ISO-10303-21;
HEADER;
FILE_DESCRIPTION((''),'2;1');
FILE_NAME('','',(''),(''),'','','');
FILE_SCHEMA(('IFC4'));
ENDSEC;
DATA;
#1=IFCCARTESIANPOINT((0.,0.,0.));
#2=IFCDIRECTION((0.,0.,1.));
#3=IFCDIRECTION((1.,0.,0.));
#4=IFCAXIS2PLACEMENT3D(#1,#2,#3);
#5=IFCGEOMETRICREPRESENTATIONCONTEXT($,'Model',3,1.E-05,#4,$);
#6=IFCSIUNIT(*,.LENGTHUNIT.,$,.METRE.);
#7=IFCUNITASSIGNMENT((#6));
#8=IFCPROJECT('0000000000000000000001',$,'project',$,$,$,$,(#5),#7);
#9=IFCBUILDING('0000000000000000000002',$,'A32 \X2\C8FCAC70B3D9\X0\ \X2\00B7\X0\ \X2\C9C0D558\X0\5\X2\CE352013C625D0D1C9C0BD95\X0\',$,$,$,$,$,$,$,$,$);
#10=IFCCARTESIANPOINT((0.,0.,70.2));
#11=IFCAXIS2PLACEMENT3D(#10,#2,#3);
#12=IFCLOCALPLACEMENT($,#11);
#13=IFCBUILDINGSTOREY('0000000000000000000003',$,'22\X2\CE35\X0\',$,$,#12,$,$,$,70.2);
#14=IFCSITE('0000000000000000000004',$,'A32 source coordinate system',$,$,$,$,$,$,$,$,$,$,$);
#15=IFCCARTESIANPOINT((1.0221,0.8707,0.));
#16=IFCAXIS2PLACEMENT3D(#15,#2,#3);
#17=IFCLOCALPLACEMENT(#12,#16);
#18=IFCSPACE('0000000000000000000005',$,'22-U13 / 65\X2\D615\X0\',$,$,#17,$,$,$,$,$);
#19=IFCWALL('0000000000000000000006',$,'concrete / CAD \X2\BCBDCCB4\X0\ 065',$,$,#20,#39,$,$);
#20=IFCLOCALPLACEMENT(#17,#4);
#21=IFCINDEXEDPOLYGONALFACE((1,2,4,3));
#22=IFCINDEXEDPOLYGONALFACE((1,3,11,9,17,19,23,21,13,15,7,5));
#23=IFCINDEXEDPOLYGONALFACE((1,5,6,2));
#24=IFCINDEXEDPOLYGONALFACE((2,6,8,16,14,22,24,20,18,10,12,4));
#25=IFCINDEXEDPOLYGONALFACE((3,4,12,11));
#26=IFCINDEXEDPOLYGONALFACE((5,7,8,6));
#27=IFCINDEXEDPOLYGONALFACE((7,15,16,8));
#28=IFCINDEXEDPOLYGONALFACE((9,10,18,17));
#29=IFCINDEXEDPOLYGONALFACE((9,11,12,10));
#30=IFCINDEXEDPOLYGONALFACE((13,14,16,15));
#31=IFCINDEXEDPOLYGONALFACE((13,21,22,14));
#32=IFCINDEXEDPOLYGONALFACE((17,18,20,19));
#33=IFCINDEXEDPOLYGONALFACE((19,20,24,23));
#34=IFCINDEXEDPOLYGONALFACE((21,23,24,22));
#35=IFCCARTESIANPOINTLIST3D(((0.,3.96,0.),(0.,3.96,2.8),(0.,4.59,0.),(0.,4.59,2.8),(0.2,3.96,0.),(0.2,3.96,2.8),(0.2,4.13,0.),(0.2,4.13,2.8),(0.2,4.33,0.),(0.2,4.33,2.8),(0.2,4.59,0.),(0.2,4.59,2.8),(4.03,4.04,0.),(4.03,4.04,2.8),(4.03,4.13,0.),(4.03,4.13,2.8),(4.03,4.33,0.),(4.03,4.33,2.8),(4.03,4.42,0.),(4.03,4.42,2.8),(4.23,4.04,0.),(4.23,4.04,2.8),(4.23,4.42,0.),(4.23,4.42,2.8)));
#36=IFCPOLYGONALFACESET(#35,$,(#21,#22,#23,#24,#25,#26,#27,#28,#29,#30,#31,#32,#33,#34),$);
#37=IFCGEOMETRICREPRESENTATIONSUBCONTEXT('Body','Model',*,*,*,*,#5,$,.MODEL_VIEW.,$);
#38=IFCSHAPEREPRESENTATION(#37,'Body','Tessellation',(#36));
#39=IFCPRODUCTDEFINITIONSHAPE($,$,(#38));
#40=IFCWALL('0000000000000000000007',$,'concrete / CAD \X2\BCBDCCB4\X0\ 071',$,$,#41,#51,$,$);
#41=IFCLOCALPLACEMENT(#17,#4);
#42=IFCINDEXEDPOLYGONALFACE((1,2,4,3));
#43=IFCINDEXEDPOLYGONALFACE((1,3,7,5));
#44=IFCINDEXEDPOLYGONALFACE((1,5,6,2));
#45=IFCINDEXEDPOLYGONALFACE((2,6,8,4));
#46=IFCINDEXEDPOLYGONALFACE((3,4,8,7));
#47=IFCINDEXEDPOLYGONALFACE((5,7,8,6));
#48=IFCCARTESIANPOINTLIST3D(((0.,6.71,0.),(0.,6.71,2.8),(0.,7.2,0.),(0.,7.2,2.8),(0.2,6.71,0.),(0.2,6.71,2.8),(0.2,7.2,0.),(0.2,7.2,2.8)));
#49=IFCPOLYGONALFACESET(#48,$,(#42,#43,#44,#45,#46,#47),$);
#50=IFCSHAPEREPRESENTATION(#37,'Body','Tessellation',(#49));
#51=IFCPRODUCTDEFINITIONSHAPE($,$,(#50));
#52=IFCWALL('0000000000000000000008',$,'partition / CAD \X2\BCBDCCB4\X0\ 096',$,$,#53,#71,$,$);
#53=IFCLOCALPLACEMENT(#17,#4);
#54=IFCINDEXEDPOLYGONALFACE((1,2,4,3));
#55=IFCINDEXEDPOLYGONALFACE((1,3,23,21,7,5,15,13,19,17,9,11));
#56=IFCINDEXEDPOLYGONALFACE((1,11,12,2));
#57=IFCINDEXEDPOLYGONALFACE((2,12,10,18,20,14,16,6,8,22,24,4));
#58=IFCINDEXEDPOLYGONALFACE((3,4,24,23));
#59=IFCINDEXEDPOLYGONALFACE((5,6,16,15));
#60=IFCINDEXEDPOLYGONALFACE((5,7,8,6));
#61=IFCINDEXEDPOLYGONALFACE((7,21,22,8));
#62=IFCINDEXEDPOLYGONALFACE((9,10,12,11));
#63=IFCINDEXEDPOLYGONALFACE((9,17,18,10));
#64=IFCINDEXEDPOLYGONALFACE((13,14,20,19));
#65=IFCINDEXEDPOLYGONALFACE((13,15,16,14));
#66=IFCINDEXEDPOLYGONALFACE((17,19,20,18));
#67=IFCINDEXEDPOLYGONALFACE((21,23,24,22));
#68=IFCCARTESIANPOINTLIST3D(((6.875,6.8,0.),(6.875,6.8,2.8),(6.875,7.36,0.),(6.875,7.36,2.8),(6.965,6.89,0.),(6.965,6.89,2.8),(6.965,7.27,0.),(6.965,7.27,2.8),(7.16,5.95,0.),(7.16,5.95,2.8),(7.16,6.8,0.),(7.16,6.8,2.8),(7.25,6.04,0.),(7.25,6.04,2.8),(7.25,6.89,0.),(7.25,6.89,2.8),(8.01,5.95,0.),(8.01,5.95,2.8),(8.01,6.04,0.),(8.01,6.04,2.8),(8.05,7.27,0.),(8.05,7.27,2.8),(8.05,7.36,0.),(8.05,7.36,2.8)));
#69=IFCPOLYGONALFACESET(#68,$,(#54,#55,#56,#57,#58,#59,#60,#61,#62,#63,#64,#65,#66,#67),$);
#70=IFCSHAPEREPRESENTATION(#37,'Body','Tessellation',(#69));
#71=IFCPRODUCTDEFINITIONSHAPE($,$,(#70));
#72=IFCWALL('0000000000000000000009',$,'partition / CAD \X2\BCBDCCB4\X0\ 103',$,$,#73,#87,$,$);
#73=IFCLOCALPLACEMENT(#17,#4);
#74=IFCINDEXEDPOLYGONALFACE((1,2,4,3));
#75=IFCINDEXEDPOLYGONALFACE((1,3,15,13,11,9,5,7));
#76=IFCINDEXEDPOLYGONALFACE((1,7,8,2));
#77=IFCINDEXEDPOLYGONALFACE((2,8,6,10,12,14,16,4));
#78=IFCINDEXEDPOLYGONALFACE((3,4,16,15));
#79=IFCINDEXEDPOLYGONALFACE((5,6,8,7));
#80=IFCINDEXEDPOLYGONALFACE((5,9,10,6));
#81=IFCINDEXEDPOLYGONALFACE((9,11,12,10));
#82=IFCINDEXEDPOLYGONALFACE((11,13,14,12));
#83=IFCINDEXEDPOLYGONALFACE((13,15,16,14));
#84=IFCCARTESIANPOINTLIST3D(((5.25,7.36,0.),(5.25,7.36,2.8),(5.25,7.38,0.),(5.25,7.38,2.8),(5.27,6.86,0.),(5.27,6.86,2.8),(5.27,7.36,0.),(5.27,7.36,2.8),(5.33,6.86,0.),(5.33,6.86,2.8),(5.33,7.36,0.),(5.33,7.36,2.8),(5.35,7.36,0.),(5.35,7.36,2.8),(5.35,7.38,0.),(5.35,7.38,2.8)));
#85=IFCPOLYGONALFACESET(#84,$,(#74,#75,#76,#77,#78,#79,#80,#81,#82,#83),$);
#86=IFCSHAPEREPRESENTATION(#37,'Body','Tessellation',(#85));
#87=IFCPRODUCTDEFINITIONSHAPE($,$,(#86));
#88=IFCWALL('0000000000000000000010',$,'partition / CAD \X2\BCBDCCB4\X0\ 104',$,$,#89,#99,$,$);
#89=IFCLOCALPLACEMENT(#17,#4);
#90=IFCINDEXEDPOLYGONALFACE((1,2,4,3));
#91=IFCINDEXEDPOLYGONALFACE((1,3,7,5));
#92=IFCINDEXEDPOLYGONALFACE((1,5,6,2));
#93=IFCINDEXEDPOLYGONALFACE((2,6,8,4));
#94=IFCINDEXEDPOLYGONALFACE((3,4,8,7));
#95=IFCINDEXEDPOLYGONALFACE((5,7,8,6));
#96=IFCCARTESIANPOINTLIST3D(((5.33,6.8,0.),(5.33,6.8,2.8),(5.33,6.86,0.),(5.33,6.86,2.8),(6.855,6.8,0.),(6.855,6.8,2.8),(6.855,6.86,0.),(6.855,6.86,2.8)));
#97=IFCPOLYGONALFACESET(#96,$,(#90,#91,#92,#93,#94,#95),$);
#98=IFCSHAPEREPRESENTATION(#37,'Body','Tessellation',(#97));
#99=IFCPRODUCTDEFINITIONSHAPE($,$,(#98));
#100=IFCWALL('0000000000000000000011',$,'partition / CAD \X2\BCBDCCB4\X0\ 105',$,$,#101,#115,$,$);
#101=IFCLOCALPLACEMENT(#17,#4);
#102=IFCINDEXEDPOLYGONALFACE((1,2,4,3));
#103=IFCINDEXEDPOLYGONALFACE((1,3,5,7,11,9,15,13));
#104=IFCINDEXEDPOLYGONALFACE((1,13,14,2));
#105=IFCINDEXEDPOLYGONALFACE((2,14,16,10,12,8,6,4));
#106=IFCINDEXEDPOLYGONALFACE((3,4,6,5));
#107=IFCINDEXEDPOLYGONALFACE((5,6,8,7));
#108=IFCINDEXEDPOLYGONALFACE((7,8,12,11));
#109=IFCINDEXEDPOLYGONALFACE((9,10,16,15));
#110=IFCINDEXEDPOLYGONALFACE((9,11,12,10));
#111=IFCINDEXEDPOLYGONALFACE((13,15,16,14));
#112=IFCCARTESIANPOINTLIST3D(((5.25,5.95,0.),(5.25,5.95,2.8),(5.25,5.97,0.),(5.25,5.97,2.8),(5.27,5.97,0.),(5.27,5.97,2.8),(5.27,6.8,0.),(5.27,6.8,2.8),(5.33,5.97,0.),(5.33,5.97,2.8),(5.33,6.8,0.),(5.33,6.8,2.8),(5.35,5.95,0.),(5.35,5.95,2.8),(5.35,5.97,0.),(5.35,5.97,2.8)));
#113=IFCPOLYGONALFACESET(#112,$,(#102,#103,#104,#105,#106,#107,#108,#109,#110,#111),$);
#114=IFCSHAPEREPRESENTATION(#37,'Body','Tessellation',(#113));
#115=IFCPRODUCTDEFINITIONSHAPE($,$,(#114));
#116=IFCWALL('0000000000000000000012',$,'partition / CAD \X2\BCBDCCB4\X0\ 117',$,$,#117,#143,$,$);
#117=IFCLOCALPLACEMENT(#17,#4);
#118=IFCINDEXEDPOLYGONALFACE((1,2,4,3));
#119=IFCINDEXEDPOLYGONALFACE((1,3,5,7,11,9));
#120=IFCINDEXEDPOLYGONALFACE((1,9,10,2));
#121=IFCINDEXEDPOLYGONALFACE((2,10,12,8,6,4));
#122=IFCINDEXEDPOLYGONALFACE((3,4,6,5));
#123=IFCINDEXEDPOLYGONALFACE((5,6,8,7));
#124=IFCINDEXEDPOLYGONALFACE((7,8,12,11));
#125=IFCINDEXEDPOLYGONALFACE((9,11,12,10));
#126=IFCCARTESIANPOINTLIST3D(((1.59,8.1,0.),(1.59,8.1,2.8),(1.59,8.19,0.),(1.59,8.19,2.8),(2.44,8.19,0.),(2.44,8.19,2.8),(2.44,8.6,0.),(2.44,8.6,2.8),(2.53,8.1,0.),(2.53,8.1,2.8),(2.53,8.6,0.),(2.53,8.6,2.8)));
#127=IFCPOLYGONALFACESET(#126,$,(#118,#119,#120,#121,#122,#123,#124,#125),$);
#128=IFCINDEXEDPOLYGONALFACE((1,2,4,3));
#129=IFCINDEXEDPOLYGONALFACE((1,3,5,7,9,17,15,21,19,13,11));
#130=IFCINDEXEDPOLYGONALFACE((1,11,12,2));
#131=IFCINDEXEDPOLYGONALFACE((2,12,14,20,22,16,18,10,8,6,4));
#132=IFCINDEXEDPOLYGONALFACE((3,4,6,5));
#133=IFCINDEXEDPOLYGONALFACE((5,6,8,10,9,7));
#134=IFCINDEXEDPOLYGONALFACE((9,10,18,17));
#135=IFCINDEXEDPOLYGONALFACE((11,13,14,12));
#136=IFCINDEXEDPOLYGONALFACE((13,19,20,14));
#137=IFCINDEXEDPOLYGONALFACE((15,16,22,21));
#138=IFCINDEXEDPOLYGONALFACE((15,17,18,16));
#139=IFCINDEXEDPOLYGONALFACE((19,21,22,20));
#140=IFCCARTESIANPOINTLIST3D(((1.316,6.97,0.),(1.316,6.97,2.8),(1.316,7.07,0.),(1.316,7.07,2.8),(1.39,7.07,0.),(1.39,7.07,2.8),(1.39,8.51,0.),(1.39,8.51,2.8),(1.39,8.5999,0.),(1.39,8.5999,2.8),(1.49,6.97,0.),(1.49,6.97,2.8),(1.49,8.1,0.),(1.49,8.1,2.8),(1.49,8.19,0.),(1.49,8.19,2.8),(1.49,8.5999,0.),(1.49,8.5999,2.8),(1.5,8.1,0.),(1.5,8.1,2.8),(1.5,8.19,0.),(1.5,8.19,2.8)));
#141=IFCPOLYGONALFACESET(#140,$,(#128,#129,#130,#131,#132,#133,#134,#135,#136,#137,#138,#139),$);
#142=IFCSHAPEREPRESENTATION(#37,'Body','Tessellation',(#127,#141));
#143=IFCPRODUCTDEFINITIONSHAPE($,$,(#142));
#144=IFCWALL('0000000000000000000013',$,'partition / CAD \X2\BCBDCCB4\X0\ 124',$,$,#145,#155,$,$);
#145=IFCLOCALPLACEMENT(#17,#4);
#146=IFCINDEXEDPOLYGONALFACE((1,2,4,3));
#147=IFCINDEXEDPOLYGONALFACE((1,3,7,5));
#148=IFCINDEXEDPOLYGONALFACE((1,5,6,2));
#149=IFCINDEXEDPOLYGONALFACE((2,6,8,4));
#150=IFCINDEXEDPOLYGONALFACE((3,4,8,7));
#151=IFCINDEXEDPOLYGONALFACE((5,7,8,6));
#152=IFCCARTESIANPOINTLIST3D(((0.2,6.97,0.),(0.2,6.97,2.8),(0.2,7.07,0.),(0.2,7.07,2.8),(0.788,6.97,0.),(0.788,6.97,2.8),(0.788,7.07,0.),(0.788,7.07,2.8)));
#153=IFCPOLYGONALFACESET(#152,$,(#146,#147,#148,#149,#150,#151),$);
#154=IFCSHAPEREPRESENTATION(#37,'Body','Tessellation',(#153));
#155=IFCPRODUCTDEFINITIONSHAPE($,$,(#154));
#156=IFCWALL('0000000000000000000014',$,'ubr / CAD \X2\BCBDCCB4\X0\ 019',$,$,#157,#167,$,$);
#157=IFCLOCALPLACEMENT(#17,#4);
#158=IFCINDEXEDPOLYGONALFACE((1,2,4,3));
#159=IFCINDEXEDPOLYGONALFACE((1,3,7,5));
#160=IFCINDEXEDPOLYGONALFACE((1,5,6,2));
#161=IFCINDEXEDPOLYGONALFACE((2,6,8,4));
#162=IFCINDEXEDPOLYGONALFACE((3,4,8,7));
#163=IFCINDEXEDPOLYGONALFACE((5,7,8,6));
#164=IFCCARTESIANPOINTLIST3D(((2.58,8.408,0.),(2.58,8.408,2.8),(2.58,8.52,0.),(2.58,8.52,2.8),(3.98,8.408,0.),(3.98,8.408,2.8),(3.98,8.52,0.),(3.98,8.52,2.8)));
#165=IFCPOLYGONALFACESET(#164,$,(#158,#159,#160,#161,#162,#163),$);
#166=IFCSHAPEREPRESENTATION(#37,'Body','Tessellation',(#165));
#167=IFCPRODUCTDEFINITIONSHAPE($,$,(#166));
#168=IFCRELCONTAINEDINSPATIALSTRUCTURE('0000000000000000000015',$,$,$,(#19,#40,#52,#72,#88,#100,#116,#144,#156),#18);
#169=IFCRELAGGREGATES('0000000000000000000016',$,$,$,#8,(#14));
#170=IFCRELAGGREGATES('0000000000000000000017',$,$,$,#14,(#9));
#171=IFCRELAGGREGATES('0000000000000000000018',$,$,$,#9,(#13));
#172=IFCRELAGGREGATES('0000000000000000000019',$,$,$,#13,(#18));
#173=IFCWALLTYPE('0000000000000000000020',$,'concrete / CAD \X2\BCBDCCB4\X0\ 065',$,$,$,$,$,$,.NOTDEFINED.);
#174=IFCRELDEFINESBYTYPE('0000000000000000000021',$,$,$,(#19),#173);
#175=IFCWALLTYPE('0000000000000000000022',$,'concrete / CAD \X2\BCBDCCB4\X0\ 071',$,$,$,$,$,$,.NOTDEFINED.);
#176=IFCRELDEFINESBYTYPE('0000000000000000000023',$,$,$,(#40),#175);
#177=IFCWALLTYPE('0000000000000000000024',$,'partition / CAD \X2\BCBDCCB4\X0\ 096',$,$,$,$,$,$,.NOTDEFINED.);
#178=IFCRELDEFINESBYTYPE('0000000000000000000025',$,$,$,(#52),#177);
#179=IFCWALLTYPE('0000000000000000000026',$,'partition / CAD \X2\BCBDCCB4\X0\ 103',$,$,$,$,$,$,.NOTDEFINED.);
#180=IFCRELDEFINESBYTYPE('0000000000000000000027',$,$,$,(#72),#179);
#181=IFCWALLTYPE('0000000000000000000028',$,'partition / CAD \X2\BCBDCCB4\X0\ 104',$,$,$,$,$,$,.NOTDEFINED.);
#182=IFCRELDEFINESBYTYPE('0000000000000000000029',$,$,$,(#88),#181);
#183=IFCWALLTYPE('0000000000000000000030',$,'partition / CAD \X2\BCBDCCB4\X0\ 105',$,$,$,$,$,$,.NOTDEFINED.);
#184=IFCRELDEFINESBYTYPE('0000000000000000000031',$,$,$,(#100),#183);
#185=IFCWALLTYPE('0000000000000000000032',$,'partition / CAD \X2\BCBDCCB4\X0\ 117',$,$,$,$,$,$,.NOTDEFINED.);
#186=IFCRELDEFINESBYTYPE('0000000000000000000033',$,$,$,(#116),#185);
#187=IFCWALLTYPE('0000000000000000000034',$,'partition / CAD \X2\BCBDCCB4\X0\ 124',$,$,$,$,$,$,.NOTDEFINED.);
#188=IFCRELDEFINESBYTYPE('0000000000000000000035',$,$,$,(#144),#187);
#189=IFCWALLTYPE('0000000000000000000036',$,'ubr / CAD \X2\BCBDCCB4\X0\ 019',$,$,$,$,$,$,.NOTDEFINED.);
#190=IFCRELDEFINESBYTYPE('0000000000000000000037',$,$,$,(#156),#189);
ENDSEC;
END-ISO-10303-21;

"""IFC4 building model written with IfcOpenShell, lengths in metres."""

from ifc_helpers import new_model, si_unit, frame, origin, origin_with_axes, place, context, subcontext, project, spatial, polyline, outline, extrude, source, transform, mapped, type_object, type_shapes, element, save


model = new_model("IFC4")

# Units and contexts
model_context = context("Model", 3, precision=1e-05, world=origin_with_axes())
body_context = subcontext(model_context, "Body", "Model", "MODEL_VIEW")
ifc_project = project(units=[si_unit("LENGTHUNIT", "METRE")], contexts=[model_context])

# Site, building, storey, space
storey_placement = place(None, frame((0.0, 0.0, 70.2), z_axis=(0.0, 0.0, 1.0), x_axis=(1.0, 0.0, 0.0)))
space_placement = place(storey_placement, frame((1.0221, 0.8707, 0.0), z_axis=(0.0, 0.0, 1.0), x_axis=(1.0, 0.0, 0.0)))
site = spatial("IfcSite", under=ifc_project, Name="A32 source coordinate system")
building = spatial("IfcBuilding", under=site, Name="A32 주거동 · 지하5층–옥탑지붕")
storey = spatial("IfcBuildingStorey", under=building, at=storey_placement, Name="22층", Elevation=70.2)
space = spatial("IfcSpace", under=storey, at=space_placement, Name="22-U13 / 65형")

# Walls
wall_type_1 = type_object("IfcWallType", Name="concrete / CAD 벽체 065", PredefinedType="NOTDEFINED")
shared_shape_1 = source(origin(), body_context, "Body", "SweptSolid", [
    extrude(outline(polyline([(0.2, 4.59), (0.2, 4.33), (4.03, 4.33), (4.03, 4.42), (4.23, 4.42), (4.23, 4.04), (4.03, 4.04), (4.03, 4.13), (0.2, 4.13), (0.2, 3.96), (0.0, 3.96), (0.0, 4.59), (0.2, 4.59)])), origin(), (0.0, 0.0, 1.0), 2.8),
])
type_shapes(wall_type_1, [shared_shape_1])
wall_1_placement = place(space_placement, origin_with_axes())
element("IfcWall", 1, at=wall_1_placement, inside=space, type_object=wall_type_1, Name="concrete / CAD 벽체 065", context=body_context, shape_type="MappedRepresentation", body=[
    mapped(shared_shape_1, transform((0.0, 0.0, 0.0), scale=1.0)),
])
wall_type_2 = type_object("IfcWallType", Name="concrete / CAD 벽체 071", PredefinedType="NOTDEFINED")
shared_shape_2 = source(origin(), body_context, "Body", "SweptSolid", [
    extrude(outline(polyline([(0.2, 6.71), (0.0, 6.71), (0.0, 7.2), (0.2, 7.2), (0.2, 6.71)])), origin(), (0.0, 0.0, 1.0), 2.8),
])
type_shapes(wall_type_2, [shared_shape_2])
wall_2_placement = place(space_placement, origin_with_axes())
element("IfcWall", 2, at=wall_2_placement, inside=space, type_object=wall_type_2, Name="concrete / CAD 벽체 071", context=body_context, shape_type="MappedRepresentation", body=[
    mapped(shared_shape_2, transform((0.0, 0.0, 0.0), scale=1.0)),
])
wall_type_3 = type_object("IfcWallType", Name="partition / CAD 벽체 096", PredefinedType="NOTDEFINED")
shared_shape_3 = source(origin(), body_context, "Body", "SweptSolid", [
    extrude(outline(polyline([(7.25, 6.04), (8.01, 6.04), (8.01, 5.95), (7.16, 5.95), (7.16, 6.8), (6.875, 6.8), (6.875, 7.36), (8.05, 7.36), (8.05, 7.27), (6.965, 7.27), (6.965, 6.89), (7.25, 6.89), (7.25, 6.04)])), origin(), (0.0, 0.0, 1.0), 2.8),
])
type_shapes(wall_type_3, [shared_shape_3])
wall_3_placement = place(space_placement, origin_with_axes())
element("IfcWall", 3, at=wall_3_placement, inside=space, type_object=wall_type_3, Name="partition / CAD 벽체 096", context=body_context, shape_type="MappedRepresentation", body=[
    mapped(shared_shape_3, transform((0.0, 0.0, 0.0), scale=1.0)),
])
wall_type_4 = type_object("IfcWallType", Name="partition / CAD 벽체 103", PredefinedType="NOTDEFINED")
shared_shape_4 = source(origin(), body_context, "Body", "SweptSolid", [
    extrude(outline(polyline([(5.27, 7.36), (5.25, 7.36), (5.25, 7.38), (5.35, 7.38), (5.35, 7.36), (5.33, 7.36), (5.33, 6.86), (5.27, 6.86), (5.27, 7.36)])), origin(), (0.0, 0.0, 1.0), 2.8),
])
type_shapes(wall_type_4, [shared_shape_4])
wall_4_placement = place(space_placement, origin_with_axes())
element("IfcWall", 4, at=wall_4_placement, inside=space, type_object=wall_type_4, Name="partition / CAD 벽체 103", context=body_context, shape_type="MappedRepresentation", body=[
    mapped(shared_shape_4, transform((0.0, 0.0, 0.0), scale=1.0)),
])
wall_type_5 = type_object("IfcWallType", Name="partition / CAD 벽체 104", PredefinedType="NOTDEFINED")
shared_shape_5 = source(origin(), body_context, "Body", "SweptSolid", [
    extrude(outline(polyline([(6.855, 6.86), (6.855, 6.8), (5.33, 6.8), (5.33, 6.86), (6.855, 6.86)])), origin(), (0.0, 0.0, 1.0), 2.8),
])
type_shapes(wall_type_5, [shared_shape_5])
wall_5_placement = place(space_placement, origin_with_axes())
element("IfcWall", 5, at=wall_5_placement, inside=space, type_object=wall_type_5, Name="partition / CAD 벽체 104", context=body_context, shape_type="MappedRepresentation", body=[
    mapped(shared_shape_5, transform((0.0, 0.0, 0.0), scale=1.0)),
])
wall_type_6 = type_object("IfcWallType", Name="partition / CAD 벽체 105", PredefinedType="NOTDEFINED")
shared_shape_6 = source(origin(), body_context, "Body", "SweptSolid", [
    extrude(outline(polyline([(5.25, 5.97), (5.27, 5.97), (5.27, 6.8), (5.33, 6.8), (5.33, 5.97), (5.35, 5.97), (5.35, 5.95), (5.25, 5.95), (5.25, 5.97)])), origin(), (0.0, 0.0, 1.0), 2.8),
])
type_shapes(wall_type_6, [shared_shape_6])
wall_6_placement = place(space_placement, origin_with_axes())
element("IfcWall", 6, at=wall_6_placement, inside=space, type_object=wall_type_6, Name="partition / CAD 벽체 105", context=body_context, shape_type="MappedRepresentation", body=[
    mapped(shared_shape_6, transform((0.0, 0.0, 0.0), scale=1.0)),
])
wall_type_7 = type_object("IfcWallType", Name="partition / CAD 벽체 117", PredefinedType="NOTDEFINED")
shared_shape_7 = source(origin(), body_context, "Body", "SweptSolid", [
    extrude(outline(polyline([(2.53, 8.1), (1.59, 8.1), (1.59, 8.19), (2.44, 8.19), (2.44, 8.6), (2.53, 8.6), (2.53, 8.1)])), origin(), (0.0, 0.0, 1.0), 2.8),
    extrude(outline(polyline([(1.49, 8.1), (1.49, 6.97), (1.316, 6.97), (1.316, 7.07), (1.39, 7.07), (1.39, 8.51), (1.39, 8.5999), (1.49, 8.5999), (1.49, 8.19), (1.5, 8.19), (1.5, 8.1), (1.49, 8.1)])), origin(), (0.0, 0.0, 1.0), 2.8),
])
type_shapes(wall_type_7, [shared_shape_7])
wall_7_placement = place(space_placement, origin_with_axes())
element("IfcWall", 7, at=wall_7_placement, inside=space, type_object=wall_type_7, Name="partition / CAD 벽체 117", context=body_context, shape_type="MappedRepresentation", body=[
    mapped(shared_shape_7, transform((0.0, 0.0, 0.0), scale=1.0)),
])
wall_type_8 = type_object("IfcWallType", Name="partition / CAD 벽체 124", PredefinedType="NOTDEFINED")
shared_shape_8 = source(origin(), body_context, "Body", "SweptSolid", [
    extrude(outline(polyline([(0.788, 7.07), (0.788, 6.97), (0.2, 6.97), (0.2, 7.07), (0.788, 7.07)])), origin(), (0.0, 0.0, 1.0), 2.8),
])
type_shapes(wall_type_8, [shared_shape_8])
wall_8_placement = place(space_placement, origin_with_axes())
element("IfcWall", 8, at=wall_8_placement, inside=space, type_object=wall_type_8, Name="partition / CAD 벽체 124", context=body_context, shape_type="MappedRepresentation", body=[
    mapped(shared_shape_8, transform((0.0, 0.0, 0.0), scale=1.0)),
])
wall_type_9 = type_object("IfcWallType", Name="ubr / CAD 벽체 019", PredefinedType="NOTDEFINED")
shared_shape_9 = source(origin(), body_context, "Body", "SweptSolid", [
    extrude(outline(polyline([(3.98, 8.408), (2.58, 8.408), (2.58, 8.52), (3.98, 8.52), (3.98, 8.408)])), origin(), (0.0, 0.0, 1.0), 2.8),
])
type_shapes(wall_type_9, [shared_shape_9])
wall_9_placement = place(space_placement, origin_with_axes())
element("IfcWall", 9, at=wall_9_placement, inside=space, type_object=wall_type_9, Name="ubr / CAD 벽체 019", context=body_context, shape_type="MappedRepresentation", body=[
    mapped(shared_shape_9, transform((0.0, 0.0, 0.0), scale=1.0)),
])

save(model, "model.ifc")
